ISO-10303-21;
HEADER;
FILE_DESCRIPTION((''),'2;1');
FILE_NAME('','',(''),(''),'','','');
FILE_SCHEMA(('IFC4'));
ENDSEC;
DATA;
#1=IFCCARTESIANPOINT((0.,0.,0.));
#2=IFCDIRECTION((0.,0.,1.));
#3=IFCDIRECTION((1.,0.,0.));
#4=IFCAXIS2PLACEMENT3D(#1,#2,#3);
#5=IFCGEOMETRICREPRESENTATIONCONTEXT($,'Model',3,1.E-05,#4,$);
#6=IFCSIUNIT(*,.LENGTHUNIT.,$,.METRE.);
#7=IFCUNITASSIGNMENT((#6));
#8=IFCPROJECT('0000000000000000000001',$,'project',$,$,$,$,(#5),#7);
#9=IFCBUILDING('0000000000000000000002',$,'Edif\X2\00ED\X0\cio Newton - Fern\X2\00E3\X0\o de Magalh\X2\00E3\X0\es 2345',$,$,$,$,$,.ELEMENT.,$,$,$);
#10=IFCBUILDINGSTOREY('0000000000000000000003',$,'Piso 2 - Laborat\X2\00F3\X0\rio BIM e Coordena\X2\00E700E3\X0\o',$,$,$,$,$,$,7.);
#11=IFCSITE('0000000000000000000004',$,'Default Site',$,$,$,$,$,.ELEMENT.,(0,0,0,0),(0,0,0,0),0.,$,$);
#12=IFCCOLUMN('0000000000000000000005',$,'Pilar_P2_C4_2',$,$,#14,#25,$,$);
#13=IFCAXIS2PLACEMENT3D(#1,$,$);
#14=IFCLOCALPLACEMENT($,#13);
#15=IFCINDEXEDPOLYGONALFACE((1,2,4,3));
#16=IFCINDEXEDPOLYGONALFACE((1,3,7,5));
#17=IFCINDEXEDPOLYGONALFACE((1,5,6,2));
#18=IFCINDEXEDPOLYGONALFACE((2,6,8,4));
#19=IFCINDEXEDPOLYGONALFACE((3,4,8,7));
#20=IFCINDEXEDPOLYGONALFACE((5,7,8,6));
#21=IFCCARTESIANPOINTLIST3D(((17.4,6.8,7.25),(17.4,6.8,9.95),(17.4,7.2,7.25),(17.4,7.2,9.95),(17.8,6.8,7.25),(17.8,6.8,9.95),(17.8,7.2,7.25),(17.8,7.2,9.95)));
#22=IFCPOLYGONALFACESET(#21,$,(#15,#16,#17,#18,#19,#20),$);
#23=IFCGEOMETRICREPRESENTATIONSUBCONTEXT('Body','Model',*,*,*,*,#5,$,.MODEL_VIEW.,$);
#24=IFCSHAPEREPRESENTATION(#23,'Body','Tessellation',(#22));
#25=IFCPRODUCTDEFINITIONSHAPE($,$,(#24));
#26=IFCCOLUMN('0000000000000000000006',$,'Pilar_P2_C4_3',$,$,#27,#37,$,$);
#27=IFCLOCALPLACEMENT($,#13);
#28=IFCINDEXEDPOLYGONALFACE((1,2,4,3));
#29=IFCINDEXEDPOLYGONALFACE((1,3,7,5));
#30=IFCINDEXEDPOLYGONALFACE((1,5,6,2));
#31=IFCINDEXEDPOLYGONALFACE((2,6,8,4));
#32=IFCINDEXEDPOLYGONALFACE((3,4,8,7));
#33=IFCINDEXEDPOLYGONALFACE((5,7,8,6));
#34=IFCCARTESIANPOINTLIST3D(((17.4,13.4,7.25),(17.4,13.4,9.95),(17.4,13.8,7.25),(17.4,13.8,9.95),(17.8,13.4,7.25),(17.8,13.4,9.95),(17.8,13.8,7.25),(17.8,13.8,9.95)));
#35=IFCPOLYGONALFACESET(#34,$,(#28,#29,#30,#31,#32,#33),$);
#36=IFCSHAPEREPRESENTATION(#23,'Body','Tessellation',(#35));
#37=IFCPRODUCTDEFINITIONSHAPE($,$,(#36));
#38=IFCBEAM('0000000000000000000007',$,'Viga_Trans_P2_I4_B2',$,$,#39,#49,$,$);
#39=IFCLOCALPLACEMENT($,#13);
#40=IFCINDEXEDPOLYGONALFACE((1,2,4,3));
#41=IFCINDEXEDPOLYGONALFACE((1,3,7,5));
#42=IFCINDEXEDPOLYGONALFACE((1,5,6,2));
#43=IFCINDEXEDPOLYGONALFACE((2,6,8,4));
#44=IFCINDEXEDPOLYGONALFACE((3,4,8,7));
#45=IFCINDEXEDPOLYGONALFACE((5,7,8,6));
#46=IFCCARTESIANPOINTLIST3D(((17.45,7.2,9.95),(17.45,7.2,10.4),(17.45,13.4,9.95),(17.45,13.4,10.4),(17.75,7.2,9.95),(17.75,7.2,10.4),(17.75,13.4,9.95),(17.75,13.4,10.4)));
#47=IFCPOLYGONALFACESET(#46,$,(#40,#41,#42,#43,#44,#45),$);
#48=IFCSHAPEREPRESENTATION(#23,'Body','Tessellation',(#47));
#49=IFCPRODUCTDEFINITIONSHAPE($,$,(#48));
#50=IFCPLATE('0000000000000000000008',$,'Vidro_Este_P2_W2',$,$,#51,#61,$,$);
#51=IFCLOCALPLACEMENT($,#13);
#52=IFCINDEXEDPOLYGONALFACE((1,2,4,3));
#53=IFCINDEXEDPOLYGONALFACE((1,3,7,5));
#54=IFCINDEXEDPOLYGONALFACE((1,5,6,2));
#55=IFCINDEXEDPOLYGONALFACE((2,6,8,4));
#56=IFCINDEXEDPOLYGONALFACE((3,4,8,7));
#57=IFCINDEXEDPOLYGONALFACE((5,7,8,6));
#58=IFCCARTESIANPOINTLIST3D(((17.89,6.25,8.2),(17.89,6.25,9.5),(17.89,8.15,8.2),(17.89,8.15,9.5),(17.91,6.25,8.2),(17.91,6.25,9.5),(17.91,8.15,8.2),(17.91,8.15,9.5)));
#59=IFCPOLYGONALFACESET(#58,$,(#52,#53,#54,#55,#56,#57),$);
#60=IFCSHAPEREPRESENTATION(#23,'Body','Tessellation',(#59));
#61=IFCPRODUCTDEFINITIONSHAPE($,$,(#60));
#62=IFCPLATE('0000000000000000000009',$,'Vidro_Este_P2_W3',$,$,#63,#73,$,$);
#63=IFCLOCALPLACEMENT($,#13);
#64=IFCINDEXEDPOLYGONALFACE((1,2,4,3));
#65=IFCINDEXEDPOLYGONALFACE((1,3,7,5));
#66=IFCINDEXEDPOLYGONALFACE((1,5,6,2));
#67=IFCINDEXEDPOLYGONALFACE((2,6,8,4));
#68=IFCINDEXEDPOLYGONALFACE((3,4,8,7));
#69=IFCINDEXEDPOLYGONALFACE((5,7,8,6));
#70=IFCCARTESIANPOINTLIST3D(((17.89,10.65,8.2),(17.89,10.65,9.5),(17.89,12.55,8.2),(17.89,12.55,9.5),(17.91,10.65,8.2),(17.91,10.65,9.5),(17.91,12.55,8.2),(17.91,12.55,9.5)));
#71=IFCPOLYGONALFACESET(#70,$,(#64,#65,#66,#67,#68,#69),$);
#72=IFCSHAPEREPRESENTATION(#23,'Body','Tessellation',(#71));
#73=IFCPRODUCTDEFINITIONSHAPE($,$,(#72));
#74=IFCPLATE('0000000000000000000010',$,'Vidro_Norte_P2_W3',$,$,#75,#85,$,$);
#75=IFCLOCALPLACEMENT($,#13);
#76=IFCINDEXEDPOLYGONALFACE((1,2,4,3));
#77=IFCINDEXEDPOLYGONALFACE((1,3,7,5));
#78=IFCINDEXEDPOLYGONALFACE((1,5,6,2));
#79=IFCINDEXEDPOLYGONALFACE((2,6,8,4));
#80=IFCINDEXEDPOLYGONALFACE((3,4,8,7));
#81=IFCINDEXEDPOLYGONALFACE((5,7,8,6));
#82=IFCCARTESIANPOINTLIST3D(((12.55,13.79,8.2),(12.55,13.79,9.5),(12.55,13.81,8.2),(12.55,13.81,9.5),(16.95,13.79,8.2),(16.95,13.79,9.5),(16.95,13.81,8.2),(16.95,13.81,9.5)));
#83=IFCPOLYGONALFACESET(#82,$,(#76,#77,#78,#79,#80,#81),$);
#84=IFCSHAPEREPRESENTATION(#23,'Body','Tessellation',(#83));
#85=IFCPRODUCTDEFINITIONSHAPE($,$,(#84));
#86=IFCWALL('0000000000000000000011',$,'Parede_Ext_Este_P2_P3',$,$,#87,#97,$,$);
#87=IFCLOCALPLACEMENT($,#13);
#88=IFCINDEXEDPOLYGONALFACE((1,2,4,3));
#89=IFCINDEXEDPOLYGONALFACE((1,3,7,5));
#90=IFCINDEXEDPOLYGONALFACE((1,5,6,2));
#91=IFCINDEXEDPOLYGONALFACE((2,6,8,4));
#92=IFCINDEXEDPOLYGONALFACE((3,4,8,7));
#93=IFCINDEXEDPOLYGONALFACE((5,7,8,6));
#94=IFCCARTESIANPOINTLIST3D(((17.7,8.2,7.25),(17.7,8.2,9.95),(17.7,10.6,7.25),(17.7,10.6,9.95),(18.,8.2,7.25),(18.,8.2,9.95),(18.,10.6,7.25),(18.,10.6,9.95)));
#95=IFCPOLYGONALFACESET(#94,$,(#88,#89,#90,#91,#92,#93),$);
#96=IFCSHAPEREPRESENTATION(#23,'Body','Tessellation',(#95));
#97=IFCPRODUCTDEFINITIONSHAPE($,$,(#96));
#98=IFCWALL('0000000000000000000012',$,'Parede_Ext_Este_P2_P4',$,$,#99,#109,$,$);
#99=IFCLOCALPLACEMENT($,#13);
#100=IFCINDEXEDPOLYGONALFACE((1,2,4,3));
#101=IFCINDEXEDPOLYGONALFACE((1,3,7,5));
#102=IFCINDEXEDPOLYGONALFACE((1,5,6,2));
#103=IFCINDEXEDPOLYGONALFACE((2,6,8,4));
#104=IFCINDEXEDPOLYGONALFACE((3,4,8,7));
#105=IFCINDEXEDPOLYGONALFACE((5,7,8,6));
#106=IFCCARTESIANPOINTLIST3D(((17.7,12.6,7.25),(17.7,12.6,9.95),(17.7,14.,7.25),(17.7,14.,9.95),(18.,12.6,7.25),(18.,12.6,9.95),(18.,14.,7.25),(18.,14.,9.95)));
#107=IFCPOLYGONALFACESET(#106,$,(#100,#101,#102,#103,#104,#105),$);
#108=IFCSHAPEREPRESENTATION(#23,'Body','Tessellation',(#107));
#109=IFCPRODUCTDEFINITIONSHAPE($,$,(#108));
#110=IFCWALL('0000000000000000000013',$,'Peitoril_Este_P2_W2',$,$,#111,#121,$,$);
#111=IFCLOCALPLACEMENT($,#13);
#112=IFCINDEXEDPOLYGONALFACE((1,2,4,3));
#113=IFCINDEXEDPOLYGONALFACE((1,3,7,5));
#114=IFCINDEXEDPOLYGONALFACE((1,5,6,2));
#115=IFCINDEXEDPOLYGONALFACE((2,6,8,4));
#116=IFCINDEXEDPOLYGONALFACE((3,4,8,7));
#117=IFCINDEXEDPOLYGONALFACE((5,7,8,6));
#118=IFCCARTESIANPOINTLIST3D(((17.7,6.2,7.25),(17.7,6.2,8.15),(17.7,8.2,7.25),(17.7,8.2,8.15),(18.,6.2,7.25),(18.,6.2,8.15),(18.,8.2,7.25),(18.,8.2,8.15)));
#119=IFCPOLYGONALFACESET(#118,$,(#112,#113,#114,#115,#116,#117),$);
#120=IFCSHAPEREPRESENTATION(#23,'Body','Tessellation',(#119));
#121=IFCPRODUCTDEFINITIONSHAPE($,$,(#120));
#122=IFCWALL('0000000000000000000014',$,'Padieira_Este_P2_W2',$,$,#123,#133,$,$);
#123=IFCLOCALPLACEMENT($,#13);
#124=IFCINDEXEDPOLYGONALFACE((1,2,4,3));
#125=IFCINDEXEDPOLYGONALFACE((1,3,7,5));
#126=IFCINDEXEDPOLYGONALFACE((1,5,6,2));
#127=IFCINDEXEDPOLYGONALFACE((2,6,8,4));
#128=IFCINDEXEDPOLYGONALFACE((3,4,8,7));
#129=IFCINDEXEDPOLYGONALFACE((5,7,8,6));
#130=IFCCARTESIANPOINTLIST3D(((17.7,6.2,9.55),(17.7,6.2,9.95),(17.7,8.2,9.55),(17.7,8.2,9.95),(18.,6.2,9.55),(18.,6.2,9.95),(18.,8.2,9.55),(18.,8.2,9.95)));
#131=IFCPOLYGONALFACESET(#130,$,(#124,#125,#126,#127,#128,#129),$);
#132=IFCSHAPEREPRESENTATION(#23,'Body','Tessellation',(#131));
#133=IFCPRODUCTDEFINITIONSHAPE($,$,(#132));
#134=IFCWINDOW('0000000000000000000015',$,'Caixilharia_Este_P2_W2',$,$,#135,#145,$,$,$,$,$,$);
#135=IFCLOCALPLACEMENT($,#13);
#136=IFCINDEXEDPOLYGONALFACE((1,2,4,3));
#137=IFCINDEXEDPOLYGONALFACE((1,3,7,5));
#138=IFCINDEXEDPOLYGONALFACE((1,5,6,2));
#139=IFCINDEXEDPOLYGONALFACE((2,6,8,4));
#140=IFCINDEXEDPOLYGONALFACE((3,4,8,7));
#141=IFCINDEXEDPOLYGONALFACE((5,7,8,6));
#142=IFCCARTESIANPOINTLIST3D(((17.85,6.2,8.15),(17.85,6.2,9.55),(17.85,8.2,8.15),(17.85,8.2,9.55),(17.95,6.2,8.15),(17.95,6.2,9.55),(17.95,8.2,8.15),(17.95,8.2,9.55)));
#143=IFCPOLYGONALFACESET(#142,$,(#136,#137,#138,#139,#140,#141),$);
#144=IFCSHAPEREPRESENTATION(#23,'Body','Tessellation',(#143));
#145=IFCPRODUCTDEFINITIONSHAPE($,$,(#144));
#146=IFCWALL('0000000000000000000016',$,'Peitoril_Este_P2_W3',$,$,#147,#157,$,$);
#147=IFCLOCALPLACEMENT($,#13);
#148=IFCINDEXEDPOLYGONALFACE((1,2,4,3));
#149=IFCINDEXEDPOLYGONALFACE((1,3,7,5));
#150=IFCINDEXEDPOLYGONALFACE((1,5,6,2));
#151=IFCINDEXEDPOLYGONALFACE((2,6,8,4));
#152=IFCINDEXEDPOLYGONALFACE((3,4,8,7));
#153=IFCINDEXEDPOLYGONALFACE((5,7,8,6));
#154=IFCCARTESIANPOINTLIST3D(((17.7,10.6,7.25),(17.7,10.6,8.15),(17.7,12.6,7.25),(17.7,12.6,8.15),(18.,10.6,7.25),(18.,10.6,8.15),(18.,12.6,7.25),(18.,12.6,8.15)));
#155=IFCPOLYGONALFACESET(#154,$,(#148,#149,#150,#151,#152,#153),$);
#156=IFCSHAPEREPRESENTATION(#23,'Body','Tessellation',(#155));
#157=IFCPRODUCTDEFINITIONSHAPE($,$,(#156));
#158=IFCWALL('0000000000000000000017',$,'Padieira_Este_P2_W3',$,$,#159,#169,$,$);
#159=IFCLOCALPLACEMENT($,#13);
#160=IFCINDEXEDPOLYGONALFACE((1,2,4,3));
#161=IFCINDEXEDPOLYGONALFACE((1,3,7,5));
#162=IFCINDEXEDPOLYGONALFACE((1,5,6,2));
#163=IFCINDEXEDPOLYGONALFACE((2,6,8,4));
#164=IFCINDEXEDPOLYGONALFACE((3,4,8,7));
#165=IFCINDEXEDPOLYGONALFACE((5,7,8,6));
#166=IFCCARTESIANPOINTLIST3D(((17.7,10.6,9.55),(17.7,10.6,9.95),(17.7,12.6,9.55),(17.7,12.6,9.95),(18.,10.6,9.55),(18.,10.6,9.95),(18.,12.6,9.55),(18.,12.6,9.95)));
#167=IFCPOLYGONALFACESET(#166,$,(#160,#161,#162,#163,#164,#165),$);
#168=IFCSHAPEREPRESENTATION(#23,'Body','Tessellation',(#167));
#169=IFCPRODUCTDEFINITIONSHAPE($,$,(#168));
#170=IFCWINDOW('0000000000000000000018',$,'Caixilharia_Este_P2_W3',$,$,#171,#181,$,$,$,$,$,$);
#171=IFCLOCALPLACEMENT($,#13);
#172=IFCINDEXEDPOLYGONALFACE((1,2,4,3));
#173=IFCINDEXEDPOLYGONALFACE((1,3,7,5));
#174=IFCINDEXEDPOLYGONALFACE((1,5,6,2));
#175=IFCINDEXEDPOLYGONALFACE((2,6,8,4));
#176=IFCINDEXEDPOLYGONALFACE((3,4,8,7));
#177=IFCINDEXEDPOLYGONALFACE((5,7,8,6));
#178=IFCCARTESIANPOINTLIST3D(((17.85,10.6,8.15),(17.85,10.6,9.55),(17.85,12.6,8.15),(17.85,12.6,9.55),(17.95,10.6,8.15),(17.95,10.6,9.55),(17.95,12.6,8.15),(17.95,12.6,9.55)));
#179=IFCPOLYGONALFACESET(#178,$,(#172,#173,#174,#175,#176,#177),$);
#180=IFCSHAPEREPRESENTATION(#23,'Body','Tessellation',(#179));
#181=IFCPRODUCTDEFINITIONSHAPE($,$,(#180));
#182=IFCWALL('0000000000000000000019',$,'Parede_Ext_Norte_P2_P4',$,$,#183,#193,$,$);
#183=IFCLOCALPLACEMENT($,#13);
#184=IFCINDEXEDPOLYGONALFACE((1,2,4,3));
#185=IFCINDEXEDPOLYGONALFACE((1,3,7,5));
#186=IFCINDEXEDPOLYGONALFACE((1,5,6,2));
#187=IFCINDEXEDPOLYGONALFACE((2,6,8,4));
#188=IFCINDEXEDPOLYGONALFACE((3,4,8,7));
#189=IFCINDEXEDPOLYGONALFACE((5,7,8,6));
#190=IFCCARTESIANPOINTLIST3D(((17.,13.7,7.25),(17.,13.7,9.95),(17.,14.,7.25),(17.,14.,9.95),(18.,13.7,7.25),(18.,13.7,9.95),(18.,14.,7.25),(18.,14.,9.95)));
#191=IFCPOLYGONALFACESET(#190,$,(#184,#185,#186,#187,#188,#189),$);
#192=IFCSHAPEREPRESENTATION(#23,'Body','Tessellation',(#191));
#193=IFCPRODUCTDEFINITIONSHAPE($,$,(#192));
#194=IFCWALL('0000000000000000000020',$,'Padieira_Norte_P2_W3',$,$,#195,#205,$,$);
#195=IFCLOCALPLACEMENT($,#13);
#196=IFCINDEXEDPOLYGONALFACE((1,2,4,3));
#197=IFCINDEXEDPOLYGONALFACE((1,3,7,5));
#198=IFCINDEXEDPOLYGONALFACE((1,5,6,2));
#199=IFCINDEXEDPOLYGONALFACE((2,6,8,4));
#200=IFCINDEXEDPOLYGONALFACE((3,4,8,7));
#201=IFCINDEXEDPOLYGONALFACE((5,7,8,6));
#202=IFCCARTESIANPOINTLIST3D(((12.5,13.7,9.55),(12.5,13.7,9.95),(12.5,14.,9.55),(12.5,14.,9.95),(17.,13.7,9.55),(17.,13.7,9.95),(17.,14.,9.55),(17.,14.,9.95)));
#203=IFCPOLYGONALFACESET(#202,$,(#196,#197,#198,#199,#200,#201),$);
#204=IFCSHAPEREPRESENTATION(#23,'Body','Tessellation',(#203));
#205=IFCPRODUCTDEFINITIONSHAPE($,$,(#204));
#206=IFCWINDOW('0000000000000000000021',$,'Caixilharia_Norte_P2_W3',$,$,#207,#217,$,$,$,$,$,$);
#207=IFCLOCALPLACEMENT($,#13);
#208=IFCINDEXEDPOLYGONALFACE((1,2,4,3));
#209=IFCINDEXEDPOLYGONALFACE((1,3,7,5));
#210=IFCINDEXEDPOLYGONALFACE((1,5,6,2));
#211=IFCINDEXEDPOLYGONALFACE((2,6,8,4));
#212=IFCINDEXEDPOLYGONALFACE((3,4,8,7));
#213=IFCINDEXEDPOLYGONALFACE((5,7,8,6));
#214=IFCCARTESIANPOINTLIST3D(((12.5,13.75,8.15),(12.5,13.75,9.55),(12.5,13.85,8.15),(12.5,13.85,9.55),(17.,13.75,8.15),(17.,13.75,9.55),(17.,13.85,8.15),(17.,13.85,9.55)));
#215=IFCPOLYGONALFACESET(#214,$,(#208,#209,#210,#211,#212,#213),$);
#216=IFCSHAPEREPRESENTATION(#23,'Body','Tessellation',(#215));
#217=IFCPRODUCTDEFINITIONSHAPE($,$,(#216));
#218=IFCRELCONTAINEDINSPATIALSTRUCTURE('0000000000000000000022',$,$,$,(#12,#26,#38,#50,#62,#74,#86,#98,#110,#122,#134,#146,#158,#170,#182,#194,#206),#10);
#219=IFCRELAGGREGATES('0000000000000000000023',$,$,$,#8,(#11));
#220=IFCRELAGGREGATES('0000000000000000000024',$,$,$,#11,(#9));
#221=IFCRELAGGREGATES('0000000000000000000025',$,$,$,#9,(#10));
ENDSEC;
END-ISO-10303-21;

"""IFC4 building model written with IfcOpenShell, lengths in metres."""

from ifc_helpers import new_model, si_unit, frame, frame_2d, origin_with_axes, place, context, subcontext, project, spatial, rectangle, extrude, element, save


model = new_model("IFC4")

# Units and contexts
model_context = context("Model", 3, precision=1e-05, world=origin_with_axes())
body_context = subcontext(model_context, "Body", "Model", "MODEL_VIEW")
ifc_project = project(units=[si_unit("LENGTHUNIT", "METRE")], contexts=[model_context])

# Site, building, storey
site = spatial("IfcSite", under=ifc_project, Name="Default Site", CompositionType="ELEMENT", RefLatitude=(0, 0, 0, 0), RefLongitude=(0, 0, 0, 0), RefElevation=0.0)
building = spatial("IfcBuilding", under=site, Name="Edifício Newton - Fernão de Magalhães 2345", CompositionType="ELEMENT")
storey = spatial("IfcBuildingStorey", under=building, Name="Piso 2 - Laboratório BIM e Coordenação", Elevation=7.0)

# Columns
for number, where, z_axis, x_axis, name in (
    (1, (17.4, 6.8, 7.25), (0.0, 0.0, 1.0), (1.0, 0.0, 0.0), "Pilar_P2_C4_2"),
    (2, (17.4, 13.4, 7.25), (0.0, 0.0, 1.0), (1.0, 0.0, 0.0), "Pilar_P2_C4_3"),
):
    element("IfcColumn", number, at=place(None, frame(where, z_axis=z_axis, x_axis=x_axis)), inside=storey, Name=name, context=body_context, shape_type="SweptSolid", body=[
        extrude(rectangle(XDim=0.4, YDim=0.4, at=frame_2d((0.2, 0.2))), origin_with_axes(), (0.0, 0.0, 1.0), 2.7),
    ])

# Beam
beam_placement = place(None, frame((17.45, 7.2, 9.95), z_axis=(0.0, 0.0, 1.0), x_axis=(1.0, 0.0, 0.0)))
element("IfcBeam", 3, at=beam_placement, inside=storey, Name="Viga_Trans_P2_I4_B2", context=body_context, shape_type="SweptSolid", body=[
    extrude(rectangle(XDim=0.3, YDim=6.2, at=frame_2d((0.15, 3.1))), origin_with_axes(), (0.0, 0.0, 1.0), 0.45),
])

# Plates
plate_1_placement = place(None, frame((17.89, 6.25, 8.2), z_axis=(0.0, 0.0, 1.0), x_axis=(1.0, 0.0, 0.0)))
element("IfcPlate", 4, at=plate_1_placement, inside=storey, Name="Vidro_Este_P2_W2", context=body_context, shape_type="SweptSolid", body=[
    extrude(rectangle(XDim=0.02, YDim=1.9, at=frame_2d((0.01, 0.95))), origin_with_axes(), (0.0, 0.0, 1.0), 1.3),
])
plate_2_placement = place(None, frame((17.89, 10.65, 8.2), z_axis=(0.0, 0.0, 1.0), x_axis=(1.0, 0.0, 0.0)))
element("IfcPlate", 5, at=plate_2_placement, inside=storey, Name="Vidro_Este_P2_W3", context=body_context, shape_type="SweptSolid", body=[
    extrude(rectangle(XDim=0.02, YDim=1.9, at=frame_2d((0.01, 0.95))), origin_with_axes(), (0.0, 0.0, 1.0), 1.3),
])
plate_3_placement = place(None, frame((12.55, 13.79, 8.2), z_axis=(0.0, 0.0, 1.0), x_axis=(1.0, 0.0, 0.0)))
element("IfcPlate", 6, at=plate_3_placement, inside=storey, Name="Vidro_Norte_P2_W3", context=body_context, shape_type="SweptSolid", body=[
    extrude(rectangle(XDim=4.4, YDim=0.02, at=frame_2d((2.2, 0.01))), origin_with_axes(), (0.0, 0.0, 1.0), 1.3),
])

# Walls
wall_1_placement = place(None, frame((17.7, 8.2, 7.25), z_axis=(0.0, 0.0, 1.0), x_axis=(1.0, 0.0, 0.0)))
element("IfcWall", 7, at=wall_1_placement, inside=storey, Name="Parede_Ext_Este_P2_P3", context=body_context, shape_type="SweptSolid", body=[
    extrude(rectangle(XDim=0.3, YDim=2.4, at=frame_2d((0.15, 1.2))), origin_with_axes(), (0.0, 0.0, 1.0), 2.7),
])
wall_2_placement = place(None, frame((17.7, 12.6, 7.25), z_axis=(0.0, 0.0, 1.0), x_axis=(1.0, 0.0, 0.0)))
element("IfcWall", 8, at=wall_2_placement, inside=storey, Name="Parede_Ext_Este_P2_P4", context=body_context, shape_type="SweptSolid", body=[
    extrude(rectangle(XDim=0.3, YDim=1.4, at=frame_2d((0.15, 0.7))), origin_with_axes(), (0.0, 0.0, 1.0), 2.7),
])
wall_3_placement = place(None, frame((17.7, 6.2, 7.25), z_axis=(0.0, 0.0, 1.0), x_axis=(1.0, 0.0, 0.0)))
element("IfcWall", 9, at=wall_3_placement, inside=storey, Name="Peitoril_Este_P2_W2", context=body_context, shape_type="SweptSolid", body=[
    extrude(rectangle(XDim=0.3, YDim=2.0, at=frame_2d((0.15, 1.0))), origin_with_axes(), (0.0, 0.0, 1.0), 0.9),
])
wall_4_placement = place(None, frame((17.7, 6.2, 9.55), z_axis=(0.0, 0.0, 1.0), x_axis=(1.0, 0.0, 0.0)))
element("IfcWall", 10, at=wall_4_placement, inside=storey, Name="Padieira_Este_P2_W2", context=body_context, shape_type="SweptSolid", body=[
    extrude(rectangle(XDim=0.3, YDim=2.0, at=frame_2d((0.15, 1.0))), origin_with_axes(), (0.0, 0.0, 1.0), 0.4),
])

# Window
window_1_placement = place(None, frame((17.85, 6.2, 8.15), z_axis=(0.0, 0.0, 1.0), x_axis=(1.0, 0.0, 0.0)))
element("IfcWindow", 11, at=window_1_placement, inside=storey, Name="Caixilharia_Este_P2_W2", context=body_context, shape_type="SweptSolid", body=[
    extrude(rectangle(XDim=0.1, YDim=2.0, at=frame_2d((0.05, 1.0))), origin_with_axes(), (0.0, 0.0, 1.0), 1.4),
])

# Walls
wall_5_placement = place(None, frame((17.7, 10.6, 7.25), z_axis=(0.0, 0.0, 1.0), x_axis=(1.0, 0.0, 0.0)))
element("IfcWall", 12, at=wall_5_placement, inside=storey, Name="Peitoril_Este_P2_W3", context=body_context, shape_type="SweptSolid", body=[
    extrude(rectangle(XDim=0.3, YDim=2.0, at=frame_2d((0.15, 1.0))), origin_with_axes(), (0.0, 0.0, 1.0), 0.9),
])
wall_6_placement = place(None, frame((17.7, 10.6, 9.55), z_axis=(0.0, 0.0, 1.0), x_axis=(1.0, 0.0, 0.0)))
element("IfcWall", 13, at=wall_6_placement, inside=storey, Name="Padieira_Este_P2_W3", context=body_context, shape_type="SweptSolid", body=[
    extrude(rectangle(XDim=0.3, YDim=2.0, at=frame_2d((0.15, 1.0))), origin_with_axes(), (0.0, 0.0, 1.0), 0.4),
])

# Window
window_2_placement = place(None, frame((17.85, 10.6, 8.15), z_axis=(0.0, 0.0, 1.0), x_axis=(1.0, 0.0, 0.0)))
element("IfcWindow", 14, at=window_2_placement, inside=storey, Name="Caixilharia_Este_P2_W3", context=body_context, shape_type="SweptSolid", body=[
    extrude(rectangle(XDim=0.1, YDim=2.0, at=frame_2d((0.05, 1.0))), origin_with_axes(), (0.0, 0.0, 1.0), 1.4),
])

# Walls
wall_7_placement = place(None, frame((17.0, 13.7, 7.25), z_axis=(0.0, 0.0, 1.0), x_axis=(1.0, 0.0, 0.0)))
element("IfcWall", 15, at=wall_7_placement, inside=storey, Name="Parede_Ext_Norte_P2_P4", context=body_context, shape_type="SweptSolid", body=[
    extrude(rectangle(XDim=1.0, YDim=0.3, at=frame_2d((0.5, 0.15))), origin_with_axes(), (0.0, 0.0, 1.0), 2.7),
])
wall_8_placement = place(None, frame((12.5, 13.7, 9.55), z_axis=(0.0, 0.0, 1.0), x_axis=(1.0, 0.0, 0.0)))
element("IfcWall", 16, at=wall_8_placement, inside=storey, Name="Padieira_Norte_P2_W3", context=body_context, shape_type="SweptSolid", body=[
    extrude(rectangle(XDim=4.5, YDim=0.3, at=frame_2d((2.25, 0.15))), origin_with_axes(), (0.0, 0.0, 1.0), 0.4),
])

# Window
window_3_placement = place(None, frame((12.5, 13.75, 8.15), z_axis=(0.0, 0.0, 1.0), x_axis=(1.0, 0.0, 0.0)))
element("IfcWindow", 17, at=window_3_placement, inside=storey, Name="Caixilharia_Norte_P2_W3", context=body_context, shape_type="SweptSolid", body=[
    extrude(rectangle(XDim=4.5, YDim=0.1, at=frame_2d((2.25, 0.05))), origin_with_axes(), (0.0, 0.0, 1.0), 1.4),
])

save(model, "model.ifc")
